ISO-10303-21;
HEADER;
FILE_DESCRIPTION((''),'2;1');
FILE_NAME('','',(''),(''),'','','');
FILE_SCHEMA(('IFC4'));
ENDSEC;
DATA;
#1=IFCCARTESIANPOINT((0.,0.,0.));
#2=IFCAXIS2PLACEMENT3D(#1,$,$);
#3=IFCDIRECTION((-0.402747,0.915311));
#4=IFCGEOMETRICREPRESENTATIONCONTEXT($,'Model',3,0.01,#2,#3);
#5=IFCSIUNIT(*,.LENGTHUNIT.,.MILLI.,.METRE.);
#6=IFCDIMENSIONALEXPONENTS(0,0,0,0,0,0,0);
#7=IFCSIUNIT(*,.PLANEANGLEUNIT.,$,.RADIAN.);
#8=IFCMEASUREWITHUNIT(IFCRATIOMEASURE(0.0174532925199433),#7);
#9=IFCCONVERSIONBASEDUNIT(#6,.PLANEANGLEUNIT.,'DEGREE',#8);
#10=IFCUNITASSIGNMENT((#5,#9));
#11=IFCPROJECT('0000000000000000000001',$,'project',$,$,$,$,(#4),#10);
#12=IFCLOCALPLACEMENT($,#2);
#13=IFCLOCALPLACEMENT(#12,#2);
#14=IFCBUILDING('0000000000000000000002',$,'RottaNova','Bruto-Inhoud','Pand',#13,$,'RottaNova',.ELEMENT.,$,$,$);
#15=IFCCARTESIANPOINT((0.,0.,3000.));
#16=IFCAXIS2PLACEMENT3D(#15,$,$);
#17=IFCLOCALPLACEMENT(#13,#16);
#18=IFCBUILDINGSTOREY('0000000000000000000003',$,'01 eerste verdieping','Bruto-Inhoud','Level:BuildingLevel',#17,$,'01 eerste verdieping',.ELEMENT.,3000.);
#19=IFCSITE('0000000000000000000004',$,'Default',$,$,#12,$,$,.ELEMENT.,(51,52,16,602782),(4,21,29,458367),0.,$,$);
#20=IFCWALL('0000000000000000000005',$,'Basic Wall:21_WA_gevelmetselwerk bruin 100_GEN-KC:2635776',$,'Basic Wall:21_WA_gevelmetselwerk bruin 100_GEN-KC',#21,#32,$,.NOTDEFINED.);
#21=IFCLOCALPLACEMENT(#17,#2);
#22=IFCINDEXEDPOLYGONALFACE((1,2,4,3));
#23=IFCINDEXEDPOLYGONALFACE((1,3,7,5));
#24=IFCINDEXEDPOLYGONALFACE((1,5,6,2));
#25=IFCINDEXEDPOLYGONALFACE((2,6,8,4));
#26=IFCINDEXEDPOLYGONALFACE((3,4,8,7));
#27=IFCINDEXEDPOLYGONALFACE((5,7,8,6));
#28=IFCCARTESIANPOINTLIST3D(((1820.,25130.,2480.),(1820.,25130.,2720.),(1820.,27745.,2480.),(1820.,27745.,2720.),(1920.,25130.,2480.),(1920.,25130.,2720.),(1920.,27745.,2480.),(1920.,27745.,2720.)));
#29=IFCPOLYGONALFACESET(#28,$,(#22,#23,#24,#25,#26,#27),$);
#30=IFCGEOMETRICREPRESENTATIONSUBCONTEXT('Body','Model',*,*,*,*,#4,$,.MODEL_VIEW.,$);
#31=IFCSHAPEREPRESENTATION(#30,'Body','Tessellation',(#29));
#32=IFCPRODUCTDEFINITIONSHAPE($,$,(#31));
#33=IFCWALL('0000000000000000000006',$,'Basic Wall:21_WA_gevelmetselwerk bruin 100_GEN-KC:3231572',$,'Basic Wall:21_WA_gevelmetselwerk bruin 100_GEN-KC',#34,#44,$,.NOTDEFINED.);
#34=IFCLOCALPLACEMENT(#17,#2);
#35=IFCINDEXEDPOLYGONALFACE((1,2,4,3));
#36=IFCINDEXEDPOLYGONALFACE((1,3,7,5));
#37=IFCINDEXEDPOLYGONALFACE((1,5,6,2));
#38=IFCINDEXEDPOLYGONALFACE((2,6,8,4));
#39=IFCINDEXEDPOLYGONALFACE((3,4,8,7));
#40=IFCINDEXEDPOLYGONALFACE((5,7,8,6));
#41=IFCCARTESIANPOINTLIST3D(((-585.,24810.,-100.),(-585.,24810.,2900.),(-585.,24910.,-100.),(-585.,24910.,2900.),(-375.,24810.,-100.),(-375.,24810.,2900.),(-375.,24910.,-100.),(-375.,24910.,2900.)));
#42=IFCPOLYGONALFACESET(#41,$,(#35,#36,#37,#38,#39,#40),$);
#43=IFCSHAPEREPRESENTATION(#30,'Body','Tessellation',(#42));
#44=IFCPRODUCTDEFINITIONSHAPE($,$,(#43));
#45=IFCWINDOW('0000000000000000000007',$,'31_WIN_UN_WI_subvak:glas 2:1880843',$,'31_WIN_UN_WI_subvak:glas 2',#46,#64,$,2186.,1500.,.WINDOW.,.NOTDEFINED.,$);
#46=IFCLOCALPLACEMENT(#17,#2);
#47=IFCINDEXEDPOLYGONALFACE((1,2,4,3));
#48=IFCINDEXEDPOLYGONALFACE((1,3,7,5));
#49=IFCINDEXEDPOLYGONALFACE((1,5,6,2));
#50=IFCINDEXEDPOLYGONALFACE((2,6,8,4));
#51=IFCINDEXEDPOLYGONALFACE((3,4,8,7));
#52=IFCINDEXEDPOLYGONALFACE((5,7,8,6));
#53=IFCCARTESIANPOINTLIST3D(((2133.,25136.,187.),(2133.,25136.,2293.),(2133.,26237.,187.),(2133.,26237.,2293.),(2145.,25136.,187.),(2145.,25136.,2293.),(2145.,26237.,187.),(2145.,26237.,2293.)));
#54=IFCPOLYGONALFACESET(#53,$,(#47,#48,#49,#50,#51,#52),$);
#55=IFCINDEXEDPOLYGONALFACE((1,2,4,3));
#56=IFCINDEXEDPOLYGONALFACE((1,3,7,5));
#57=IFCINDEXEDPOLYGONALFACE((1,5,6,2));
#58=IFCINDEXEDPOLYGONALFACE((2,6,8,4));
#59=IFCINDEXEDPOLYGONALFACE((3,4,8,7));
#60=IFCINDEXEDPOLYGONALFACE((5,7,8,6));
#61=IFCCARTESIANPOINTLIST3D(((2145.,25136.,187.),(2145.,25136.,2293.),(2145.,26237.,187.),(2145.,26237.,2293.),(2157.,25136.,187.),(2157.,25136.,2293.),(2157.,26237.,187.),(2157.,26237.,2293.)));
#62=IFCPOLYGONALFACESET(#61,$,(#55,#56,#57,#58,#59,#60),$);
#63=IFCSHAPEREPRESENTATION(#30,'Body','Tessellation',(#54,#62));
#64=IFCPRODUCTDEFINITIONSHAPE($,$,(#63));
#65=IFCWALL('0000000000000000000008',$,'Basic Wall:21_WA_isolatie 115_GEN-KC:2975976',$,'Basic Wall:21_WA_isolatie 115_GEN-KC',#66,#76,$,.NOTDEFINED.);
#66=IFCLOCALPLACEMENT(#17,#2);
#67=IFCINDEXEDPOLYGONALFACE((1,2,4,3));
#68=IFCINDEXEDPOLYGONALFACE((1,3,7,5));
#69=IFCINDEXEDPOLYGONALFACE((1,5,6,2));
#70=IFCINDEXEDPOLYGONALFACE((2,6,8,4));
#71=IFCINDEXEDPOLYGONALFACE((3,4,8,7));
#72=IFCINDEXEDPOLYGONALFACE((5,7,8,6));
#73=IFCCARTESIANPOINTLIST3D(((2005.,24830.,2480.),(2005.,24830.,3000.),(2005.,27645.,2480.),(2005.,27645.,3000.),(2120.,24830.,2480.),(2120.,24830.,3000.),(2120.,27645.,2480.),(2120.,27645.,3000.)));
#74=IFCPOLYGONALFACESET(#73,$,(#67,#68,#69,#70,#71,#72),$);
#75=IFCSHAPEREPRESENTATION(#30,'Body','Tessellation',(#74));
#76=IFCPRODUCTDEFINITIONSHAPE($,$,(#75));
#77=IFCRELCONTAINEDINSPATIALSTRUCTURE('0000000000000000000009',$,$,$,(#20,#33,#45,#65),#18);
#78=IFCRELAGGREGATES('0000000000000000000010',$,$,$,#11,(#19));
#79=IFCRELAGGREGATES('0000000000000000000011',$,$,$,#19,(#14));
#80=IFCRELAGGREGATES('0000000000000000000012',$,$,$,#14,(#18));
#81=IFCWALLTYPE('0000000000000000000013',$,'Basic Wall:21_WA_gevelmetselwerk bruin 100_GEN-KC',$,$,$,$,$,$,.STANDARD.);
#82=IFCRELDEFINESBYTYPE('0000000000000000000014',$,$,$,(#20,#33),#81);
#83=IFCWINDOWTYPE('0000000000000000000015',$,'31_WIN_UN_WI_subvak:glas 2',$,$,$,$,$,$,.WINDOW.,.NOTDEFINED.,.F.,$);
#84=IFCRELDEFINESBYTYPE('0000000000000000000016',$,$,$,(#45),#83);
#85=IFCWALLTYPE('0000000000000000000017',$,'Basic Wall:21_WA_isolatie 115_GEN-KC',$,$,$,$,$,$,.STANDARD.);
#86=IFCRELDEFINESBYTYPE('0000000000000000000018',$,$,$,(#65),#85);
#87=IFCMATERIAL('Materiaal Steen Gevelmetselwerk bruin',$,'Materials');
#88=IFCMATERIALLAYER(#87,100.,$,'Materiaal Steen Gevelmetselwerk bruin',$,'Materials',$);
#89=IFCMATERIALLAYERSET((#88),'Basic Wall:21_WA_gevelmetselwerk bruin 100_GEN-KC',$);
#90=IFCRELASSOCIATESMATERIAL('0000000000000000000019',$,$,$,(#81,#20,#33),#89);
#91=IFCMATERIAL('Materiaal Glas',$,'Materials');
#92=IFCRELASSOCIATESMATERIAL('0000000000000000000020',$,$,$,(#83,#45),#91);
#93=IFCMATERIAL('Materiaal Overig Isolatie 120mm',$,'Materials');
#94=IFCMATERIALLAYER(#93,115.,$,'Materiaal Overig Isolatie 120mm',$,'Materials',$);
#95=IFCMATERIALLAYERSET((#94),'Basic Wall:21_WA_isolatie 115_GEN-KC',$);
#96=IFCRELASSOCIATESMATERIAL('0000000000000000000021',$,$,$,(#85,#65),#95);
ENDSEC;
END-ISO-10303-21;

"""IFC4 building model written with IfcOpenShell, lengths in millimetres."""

from ifc_helpers import new_model, entity, si_unit, converted_unit, direction, frame, frame_2d, origin, origin_2d_with_axis, place, context, subcontext, project, spatial, rectangle, extrude, source, transform, mapped, material, layer, layer_set, type_object, type_shapes, element, save


model = new_model("IFC4")

# Units and contexts
model_context = context("Model", 3, precision=0.01, world=origin(), true_north=direction((-0.402747, 0.915311)))
body_context = subcontext(model_context, "Body", "Model", "MODEL_VIEW")
ifc_project = project(units=[si_unit("LENGTHUNIT", "METRE", prefix="MILLI"), converted_unit("PLANEANGLEUNIT", "DEGREE", entity("IfcRatioMeasure", 0.0174532925199433), si_unit("PLANEANGLEUNIT", "RADIAN"), dimensions=[0, 0, 0, 0, 0, 0, 0])], contexts=[model_context])

# Site, building, storey
site_placement = place(None, origin())
site = spatial("IfcSite", under=ifc_project, at=site_placement, Name="Default", CompositionType="ELEMENT", RefLatitude=(51, 52, 16, 602782), RefLongitude=(4, 21, 29, 458367), RefElevation=0.0)
building_placement = place(site_placement, origin())
building = spatial("IfcBuilding", under=site, at=building_placement, Name="RottaNova", Description="Bruto-Inhoud", ObjectType="Pand", LongName="RottaNova", CompositionType="ELEMENT")
storey_placement = place(building_placement, frame((0.0, 0.0, 3000.0)))
storey = spatial("IfcBuildingStorey", under=building, at=storey_placement, Name="01 eerste verdieping", Description="Bruto-Inhoud", ObjectType="Level:BuildingLevel", LongName="01 eerste verdieping", CompositionType="ELEMENT", Elevation=3000.0)

# Shared definitions
ifc_material_1 = material(Name="Materiaal Glas", Category="Materials")

# Shared definitions
ifc_material_2 = material(Name="Materiaal Steen Gevelmetselwerk bruin", Category="Materials")
ifc_layer_1 = layer(ifc_material_2, 100.0, Name="Materiaal Steen Gevelmetselwerk bruin", Category="Materials")
ifc_layer_set_1 = layer_set([ifc_layer_1], Name="Basic Wall:21_WA_gevelmetselwerk bruin 100_GEN-KC")
wall_type_1 = type_object("IfcWallType", Name="Basic Wall:21_WA_gevelmetselwerk bruin 100_GEN-KC", PredefinedType="STANDARD", material=ifc_layer_set_1)

# Walls
wall_1_placement = place(storey_placement, frame((1870.0, 25130.0, 2480.0), z_axis=(0.0, 0.0, 1.0), x_axis=(0.0, 1.0, 0.0)))
element("IfcWall", 1, at=wall_1_placement, inside=storey, type_object=wall_type_1, material=ifc_layer_set_1, Name="Basic Wall:21_WA_gevelmetselwerk bruin 100_GEN-KC:2635776", ObjectType="Basic Wall:21_WA_gevelmetselwerk bruin 100_GEN-KC", PredefinedType="NOTDEFINED", context=body_context, shape_type="SweptSolid", body=[
    extrude(rectangle(XDim=2615.0, YDim=100.0, at=frame_2d((1307.5, 0.0), x_axis=(-1.0, 0.0))), origin(), (0.0, 0.0, 1.0), 240.0),
])
wall_2_placement = place(storey_placement, frame((-585.0, 24860.0, -100.0)))
element("IfcWall", 2, at=wall_2_placement, inside=storey, type_object=wall_type_1, material=ifc_layer_set_1, Name="Basic Wall:21_WA_gevelmetselwerk bruin 100_GEN-KC:3231572", ObjectType="Basic Wall:21_WA_gevelmetselwerk bruin 100_GEN-KC", PredefinedType="NOTDEFINED", context=body_context, shape_type="SweptSolid", body=[
    extrude(rectangle(XDim=210.0, YDim=100.0, at=frame_2d((105.0, 0.0), x_axis=(-1.0, 0.0))), origin(), (0.0, 0.0, 1.0), 3000.0),
])

# Window
window_type = type_object("IfcWindowType", Name="31_WIN_UN_WI_subvak:glas 2", ParameterTakesPrecedence=False, PartitioningType="NOTDEFINED", PredefinedType="WINDOW", material=ifc_material_1)
shared_shape_1 = source(origin(), body_context, "Body", "SweptSolid", [
    extrude(rectangle(XDim=1101.0, YDim=12.0, at=origin_2d_with_axis()), frame((0.0, -6.0, 0.0)), (0.0, 0.0, 1.0), 2106.0),
    extrude(rectangle(XDim=1101.0, YDim=12.0, at=origin_2d_with_axis()), frame((0.0, 6.0, 0.0)), (0.0, 0.0, 1.0), 2106.0),
])
type_shapes(window_type, [shared_shape_1])
window_placement = place(storey_placement, frame((2145.0, 25686.5, 187.0), z_axis=(0.0, 0.0, 1.0), x_axis=(0.0, -1.0, 0.0)))
element("IfcWindow", 3, at=window_placement, inside=storey, type_object=window_type, material=ifc_material_1, Name="31_WIN_UN_WI_subvak:glas 2:1880843", ObjectType="31_WIN_UN_WI_subvak:glas 2", OverallHeight=2186.0, OverallWidth=1500.0, PartitioningType="NOTDEFINED", PredefinedType="WINDOW", context=body_context, shape_type="MappedRepresentation", body=[
    mapped(shared_shape_1, transform((0.0, 0.0, 0.0), scale=1.0)),
])

# Shared definitions
ifc_material_3 = material(Name="Materiaal Overig Isolatie 120mm", Category="Materials")
ifc_layer_2 = layer(ifc_material_3, 115.0, Name="Materiaal Overig Isolatie 120mm", Category="Materials")
ifc_layer_set_2 = layer_set([ifc_layer_2], Name="Basic Wall:21_WA_isolatie 115_GEN-KC")
wall_type_2 = type_object("IfcWallType", Name="Basic Wall:21_WA_isolatie 115_GEN-KC", PredefinedType="STANDARD", material=ifc_layer_set_2)

# Wall
wall_3_placement = place(storey_placement, frame((2062.5, 24830.0, 2480.0), z_axis=(0.0, 0.0, 1.0), x_axis=(0.0, 1.0, 0.0)))
element("IfcWall", 4, at=wall_3_placement, inside=storey, type_object=wall_type_2, material=ifc_layer_set_2, Name="Basic Wall:21_WA_isolatie 115_GEN-KC:2975976", ObjectType="Basic Wall:21_WA_isolatie 115_GEN-KC", PredefinedType="NOTDEFINED", context=body_context, shape_type="SweptSolid", body=[
    extrude(rectangle(XDim=2815.0, YDim=115.0, at=frame_2d((1407.5, 0.0), x_axis=(-1.0, 0.0))), origin(), (0.0, 0.0, 1.0), 520.0),
])

save(model, "model.ifc")
